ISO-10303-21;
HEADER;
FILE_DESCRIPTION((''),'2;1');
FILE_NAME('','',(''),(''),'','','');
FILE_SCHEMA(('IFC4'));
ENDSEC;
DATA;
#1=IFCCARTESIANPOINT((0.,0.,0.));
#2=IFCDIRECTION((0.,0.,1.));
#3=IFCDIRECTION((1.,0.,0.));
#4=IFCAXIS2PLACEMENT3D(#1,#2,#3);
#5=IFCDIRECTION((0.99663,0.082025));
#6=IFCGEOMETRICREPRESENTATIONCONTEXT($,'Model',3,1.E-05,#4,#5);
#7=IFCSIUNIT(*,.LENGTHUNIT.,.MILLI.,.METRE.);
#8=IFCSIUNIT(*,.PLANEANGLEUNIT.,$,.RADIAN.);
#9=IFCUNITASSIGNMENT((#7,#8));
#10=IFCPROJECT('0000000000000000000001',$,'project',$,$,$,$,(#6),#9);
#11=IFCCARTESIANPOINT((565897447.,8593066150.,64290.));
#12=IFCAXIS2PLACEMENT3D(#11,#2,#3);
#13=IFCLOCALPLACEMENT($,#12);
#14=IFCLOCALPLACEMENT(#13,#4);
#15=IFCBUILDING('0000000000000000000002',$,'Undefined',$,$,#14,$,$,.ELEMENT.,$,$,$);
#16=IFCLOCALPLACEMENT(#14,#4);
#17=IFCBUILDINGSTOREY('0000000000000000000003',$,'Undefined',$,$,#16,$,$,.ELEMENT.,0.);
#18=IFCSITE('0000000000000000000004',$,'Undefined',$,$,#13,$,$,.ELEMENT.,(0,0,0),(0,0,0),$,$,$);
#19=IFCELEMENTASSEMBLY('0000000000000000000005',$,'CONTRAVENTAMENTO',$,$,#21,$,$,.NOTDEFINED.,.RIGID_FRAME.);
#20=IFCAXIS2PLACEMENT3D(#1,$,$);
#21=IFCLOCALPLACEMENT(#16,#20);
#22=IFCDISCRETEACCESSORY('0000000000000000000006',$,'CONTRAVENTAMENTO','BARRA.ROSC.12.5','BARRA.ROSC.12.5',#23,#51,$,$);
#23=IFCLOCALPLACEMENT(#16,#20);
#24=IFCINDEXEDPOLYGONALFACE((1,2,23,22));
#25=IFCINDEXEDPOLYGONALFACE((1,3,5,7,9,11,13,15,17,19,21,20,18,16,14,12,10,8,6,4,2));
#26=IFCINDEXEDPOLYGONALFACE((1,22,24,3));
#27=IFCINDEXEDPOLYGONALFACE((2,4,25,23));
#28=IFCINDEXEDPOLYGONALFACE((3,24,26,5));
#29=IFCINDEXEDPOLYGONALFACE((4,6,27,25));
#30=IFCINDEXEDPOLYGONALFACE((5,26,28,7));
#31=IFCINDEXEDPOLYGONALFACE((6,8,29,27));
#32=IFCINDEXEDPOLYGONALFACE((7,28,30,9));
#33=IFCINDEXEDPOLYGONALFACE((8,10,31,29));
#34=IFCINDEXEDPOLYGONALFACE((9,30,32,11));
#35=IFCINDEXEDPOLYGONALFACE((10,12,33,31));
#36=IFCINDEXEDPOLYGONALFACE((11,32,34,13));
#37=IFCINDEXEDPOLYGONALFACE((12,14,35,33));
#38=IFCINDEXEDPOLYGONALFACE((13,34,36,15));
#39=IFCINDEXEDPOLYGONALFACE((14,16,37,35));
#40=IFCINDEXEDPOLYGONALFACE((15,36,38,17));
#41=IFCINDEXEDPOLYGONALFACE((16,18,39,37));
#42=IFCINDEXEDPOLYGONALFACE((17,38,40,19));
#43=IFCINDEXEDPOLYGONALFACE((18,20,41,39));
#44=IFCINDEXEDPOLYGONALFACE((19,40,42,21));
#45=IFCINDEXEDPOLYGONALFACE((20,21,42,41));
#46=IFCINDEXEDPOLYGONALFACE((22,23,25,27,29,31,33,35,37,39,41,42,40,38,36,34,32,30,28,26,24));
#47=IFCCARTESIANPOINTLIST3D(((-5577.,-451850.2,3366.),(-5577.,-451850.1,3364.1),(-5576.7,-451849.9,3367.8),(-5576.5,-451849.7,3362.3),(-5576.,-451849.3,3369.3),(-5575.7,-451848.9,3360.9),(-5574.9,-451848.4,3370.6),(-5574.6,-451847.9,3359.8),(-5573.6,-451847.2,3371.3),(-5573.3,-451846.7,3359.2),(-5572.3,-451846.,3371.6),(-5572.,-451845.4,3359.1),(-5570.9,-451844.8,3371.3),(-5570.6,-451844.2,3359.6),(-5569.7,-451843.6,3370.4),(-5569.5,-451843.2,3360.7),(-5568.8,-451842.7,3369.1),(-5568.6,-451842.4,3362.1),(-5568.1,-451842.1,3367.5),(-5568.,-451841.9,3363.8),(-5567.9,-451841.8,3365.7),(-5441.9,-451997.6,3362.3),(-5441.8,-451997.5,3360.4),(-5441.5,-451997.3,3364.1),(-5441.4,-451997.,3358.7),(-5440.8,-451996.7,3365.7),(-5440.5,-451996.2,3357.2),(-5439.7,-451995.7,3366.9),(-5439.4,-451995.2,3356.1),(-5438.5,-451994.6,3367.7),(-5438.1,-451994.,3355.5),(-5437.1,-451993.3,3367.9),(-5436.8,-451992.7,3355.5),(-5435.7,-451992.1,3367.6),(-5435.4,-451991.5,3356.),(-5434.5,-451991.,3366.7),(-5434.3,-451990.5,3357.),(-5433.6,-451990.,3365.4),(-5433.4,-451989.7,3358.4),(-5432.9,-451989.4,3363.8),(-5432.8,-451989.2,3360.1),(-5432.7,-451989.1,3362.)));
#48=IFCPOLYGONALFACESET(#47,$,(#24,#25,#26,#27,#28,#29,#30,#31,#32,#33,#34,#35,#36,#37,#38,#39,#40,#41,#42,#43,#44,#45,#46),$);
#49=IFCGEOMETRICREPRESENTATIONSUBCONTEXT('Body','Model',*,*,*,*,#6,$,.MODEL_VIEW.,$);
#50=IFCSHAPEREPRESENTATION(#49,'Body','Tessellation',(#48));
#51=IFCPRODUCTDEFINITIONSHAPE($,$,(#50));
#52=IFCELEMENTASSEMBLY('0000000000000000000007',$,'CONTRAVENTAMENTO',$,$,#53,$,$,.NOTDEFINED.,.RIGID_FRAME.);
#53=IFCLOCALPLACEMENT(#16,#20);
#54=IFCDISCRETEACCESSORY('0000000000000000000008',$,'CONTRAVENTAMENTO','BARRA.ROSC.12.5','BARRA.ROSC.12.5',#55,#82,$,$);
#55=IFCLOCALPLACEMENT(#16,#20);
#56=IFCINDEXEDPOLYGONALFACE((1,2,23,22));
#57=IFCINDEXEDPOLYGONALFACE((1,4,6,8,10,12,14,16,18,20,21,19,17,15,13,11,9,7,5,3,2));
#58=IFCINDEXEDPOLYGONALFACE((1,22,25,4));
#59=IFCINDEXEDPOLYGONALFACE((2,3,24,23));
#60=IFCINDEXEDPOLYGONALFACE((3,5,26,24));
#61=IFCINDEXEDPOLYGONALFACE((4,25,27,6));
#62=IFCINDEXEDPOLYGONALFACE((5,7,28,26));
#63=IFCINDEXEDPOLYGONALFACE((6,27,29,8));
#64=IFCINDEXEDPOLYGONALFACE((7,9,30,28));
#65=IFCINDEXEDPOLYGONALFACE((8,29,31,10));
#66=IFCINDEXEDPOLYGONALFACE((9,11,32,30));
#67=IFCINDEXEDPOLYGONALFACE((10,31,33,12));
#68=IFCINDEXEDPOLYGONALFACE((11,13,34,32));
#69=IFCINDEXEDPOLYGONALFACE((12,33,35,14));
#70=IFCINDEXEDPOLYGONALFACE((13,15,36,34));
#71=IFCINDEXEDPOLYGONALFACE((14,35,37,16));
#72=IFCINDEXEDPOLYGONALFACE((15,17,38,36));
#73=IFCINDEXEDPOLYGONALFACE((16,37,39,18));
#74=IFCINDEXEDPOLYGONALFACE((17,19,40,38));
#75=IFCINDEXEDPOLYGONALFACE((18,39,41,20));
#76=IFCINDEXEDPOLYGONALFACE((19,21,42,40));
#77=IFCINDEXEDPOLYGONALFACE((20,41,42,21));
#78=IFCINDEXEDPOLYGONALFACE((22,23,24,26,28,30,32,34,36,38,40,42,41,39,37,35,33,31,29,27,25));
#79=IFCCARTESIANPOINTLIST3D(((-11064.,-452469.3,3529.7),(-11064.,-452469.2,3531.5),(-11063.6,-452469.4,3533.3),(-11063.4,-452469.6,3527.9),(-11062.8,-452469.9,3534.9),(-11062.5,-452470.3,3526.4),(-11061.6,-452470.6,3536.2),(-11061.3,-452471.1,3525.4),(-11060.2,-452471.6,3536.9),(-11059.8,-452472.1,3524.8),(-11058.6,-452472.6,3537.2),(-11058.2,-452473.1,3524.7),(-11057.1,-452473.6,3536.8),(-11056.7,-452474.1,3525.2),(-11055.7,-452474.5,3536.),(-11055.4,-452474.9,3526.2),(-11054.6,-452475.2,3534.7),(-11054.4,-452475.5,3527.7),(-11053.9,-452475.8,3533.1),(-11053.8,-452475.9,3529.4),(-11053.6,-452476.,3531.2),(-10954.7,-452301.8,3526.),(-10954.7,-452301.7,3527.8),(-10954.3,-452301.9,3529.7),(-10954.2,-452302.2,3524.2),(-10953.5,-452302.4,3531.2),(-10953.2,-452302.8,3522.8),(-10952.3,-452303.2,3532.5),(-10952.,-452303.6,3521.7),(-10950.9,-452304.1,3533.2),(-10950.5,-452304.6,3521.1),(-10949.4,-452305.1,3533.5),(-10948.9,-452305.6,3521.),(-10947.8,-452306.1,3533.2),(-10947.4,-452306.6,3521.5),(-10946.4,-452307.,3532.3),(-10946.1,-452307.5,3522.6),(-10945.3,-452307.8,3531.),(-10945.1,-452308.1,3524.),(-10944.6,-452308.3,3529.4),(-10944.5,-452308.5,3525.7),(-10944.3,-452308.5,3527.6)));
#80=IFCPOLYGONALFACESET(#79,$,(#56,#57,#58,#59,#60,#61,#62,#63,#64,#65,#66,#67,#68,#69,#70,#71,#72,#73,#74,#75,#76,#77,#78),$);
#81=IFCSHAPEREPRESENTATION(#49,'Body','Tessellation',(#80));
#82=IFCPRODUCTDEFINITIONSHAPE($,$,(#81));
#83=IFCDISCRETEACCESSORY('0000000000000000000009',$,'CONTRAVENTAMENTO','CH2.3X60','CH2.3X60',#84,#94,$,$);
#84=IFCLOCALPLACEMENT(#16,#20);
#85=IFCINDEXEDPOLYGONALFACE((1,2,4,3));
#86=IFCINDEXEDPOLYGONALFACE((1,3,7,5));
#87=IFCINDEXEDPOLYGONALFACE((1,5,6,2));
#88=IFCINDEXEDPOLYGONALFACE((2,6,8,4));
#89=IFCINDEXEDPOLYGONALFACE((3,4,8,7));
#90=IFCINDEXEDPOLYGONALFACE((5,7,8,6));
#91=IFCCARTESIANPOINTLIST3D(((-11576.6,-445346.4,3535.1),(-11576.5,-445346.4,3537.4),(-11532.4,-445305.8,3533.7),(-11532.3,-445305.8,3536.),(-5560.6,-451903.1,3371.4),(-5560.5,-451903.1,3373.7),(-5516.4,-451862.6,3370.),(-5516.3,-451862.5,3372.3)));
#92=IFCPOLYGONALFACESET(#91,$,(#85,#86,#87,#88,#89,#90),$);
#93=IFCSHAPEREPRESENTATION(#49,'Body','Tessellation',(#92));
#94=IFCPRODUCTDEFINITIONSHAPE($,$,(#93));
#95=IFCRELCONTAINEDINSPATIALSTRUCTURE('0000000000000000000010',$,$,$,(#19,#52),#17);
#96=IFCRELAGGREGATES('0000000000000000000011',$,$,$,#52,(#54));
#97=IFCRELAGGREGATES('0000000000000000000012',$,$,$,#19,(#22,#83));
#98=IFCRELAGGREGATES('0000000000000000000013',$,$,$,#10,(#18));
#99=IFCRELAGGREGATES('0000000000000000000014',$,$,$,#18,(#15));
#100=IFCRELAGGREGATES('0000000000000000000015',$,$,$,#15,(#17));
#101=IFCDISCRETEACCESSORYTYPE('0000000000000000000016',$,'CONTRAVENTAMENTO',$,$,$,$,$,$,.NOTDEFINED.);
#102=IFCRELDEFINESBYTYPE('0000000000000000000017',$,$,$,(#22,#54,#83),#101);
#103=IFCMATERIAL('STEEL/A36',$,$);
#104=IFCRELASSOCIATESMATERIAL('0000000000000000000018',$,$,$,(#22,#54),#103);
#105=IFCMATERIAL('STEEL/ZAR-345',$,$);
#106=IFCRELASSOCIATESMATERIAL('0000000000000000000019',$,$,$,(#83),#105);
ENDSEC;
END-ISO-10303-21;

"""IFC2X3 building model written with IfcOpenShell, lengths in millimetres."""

from ifc_helpers import new_model, si_unit, direction, frame, origin_with_axes, origin_2d_with_axis, place, context, subcontext, project, spatial, polyline, circle, outline, extrude, material, type_object, element, aggregate, save


model = new_model("IFC2X3")

# Units and contexts
model_context = context("Model", 3, precision=1e-05, world=origin_with_axes(), true_north=direction((0.99663, 0.082025)))
body_context = subcontext(model_context, "Body", "Model", "MODEL_VIEW")
ifc_project = project(units=[si_unit("LENGTHUNIT", "METRE", prefix="MILLI"), si_unit("PLANEANGLEUNIT", "RADIAN")], contexts=[model_context])

# Site, building, storey
site_placement = place(None, frame((565897447.0, 8593066150.0, 64290.0), z_axis=(0.0, 0.0, 1.0), x_axis=(1.0, 0.0, 0.0)))
site = spatial("IfcSite", under=ifc_project, at=site_placement, Name="Undefined", CompositionType="ELEMENT", RefLatitude=(0, 0, 0), RefLongitude=(0, 0, 0))
building_placement = place(site_placement, origin_with_axes())
building = spatial("IfcBuilding", under=site, at=building_placement, Name="Undefined", CompositionType="ELEMENT")
storey_placement = place(building_placement, origin_with_axes())
storey = spatial("IfcBuildingStorey", under=building, at=storey_placement, Name="Undefined", CompositionType="ELEMENT", Elevation=0.0)

# Shared definitions
ifc_material_1 = material(Name="STEEL/A36")

# Element assemblies, discrete accessories
assembly_1_placement = place(storey_placement, origin_with_axes())
assembly_1 = element("IfcElementAssembly", 1, at=assembly_1_placement, inside=storey, Name="CONTRAVENTAMENTO", AssemblyPlace="NOTDEFINED", PredefinedType="RIGID_FRAME")
discrete_accessory_type_1 = type_object("IfcDiscreteAccessoryType", Name="CONTRAVENTAMENTO")
discrete_accessory_1_placement = place(assembly_1_placement, frame((-5437.3, -451993.4, 3361.7), z_axis=(-0.736334, -0.676203, 0.02368), x_axis=(-0.675958, 0.736711, 0.018398)))
discrete_accessory_1 = element("IfcDiscreteAccessory", 2, at=discrete_accessory_1_placement, type_object=discrete_accessory_type_1, material=ifc_material_1, Name="CONTRAVENTAMENTO", Description="BARRA.ROSC.12.5", ObjectType="BARRA.ROSC.12.5", context=body_context, shape_type="SweptSolid", body=[
    extrude(circle(Radius=6.2, at=origin_2d_with_axis()), frame((200.0, 0.0, 0.0), z_axis=(-1.0, 0.0, 0.0), x_axis=(0.0, -1.0, 0.0)), (0.0, 0.0, 1.0), 200.0),
])
assembly_2_placement = place(storey_placement, origin_with_axes())
assembly_2 = element("IfcElementAssembly", 3, at=assembly_2_placement, inside=storey, Name="CONTRAVENTAMENTO", AssemblyPlace="NOTDEFINED", PredefinedType="RIGID_FRAME")
discrete_accessory_2_placement = place(assembly_2_placement, frame((-11058.8, -452472.6, 3530.9), z_axis=(-0.836984, 0.546715, 0.02368), x_axis=(0.546411, 0.837315, -0.018398)))
discrete_accessory_2 = element("IfcDiscreteAccessory", 4, at=discrete_accessory_2_placement, type_object=discrete_accessory_type_1, material=ifc_material_1, Name="CONTRAVENTAMENTO", Description="BARRA.ROSC.12.5", ObjectType="BARRA.ROSC.12.5", context=body_context, shape_type="SweptSolid", body=[
    extrude(circle(Radius=6.2, at=origin_2d_with_axis()), frame((200.0, 0.0, 0.0), z_axis=(-1.0, 0.0, 0.0), x_axis=(0.0, -1.0, 0.0)), (0.0, 0.0, 1.0), 200.0),
])
aggregate(assembly_2, [discrete_accessory_2])

# Discrete accessory
ifc_material_2 = material(Name="STEEL/ZAR-345")
discrete_accessory_3_placement = place(assembly_1_placement, frame((-5538.5, -451882.8, 3371.8), z_axis=(0.029885, 0.00246, 0.99955), x_axis=(-0.675958, 0.736711, 0.018398)))
discrete_accessory_3 = element("IfcDiscreteAccessory", 5, at=discrete_accessory_3_placement, type_object=discrete_accessory_type_1, material=ifc_material_2, Name="CONTRAVENTAMENTO", Description="CH2.3X60", ObjectType="CH2.3X60", context=body_context, shape_type="SweptSolid", body=[
    extrude(outline(polyline([(8900.0, -30.0), (0.0, -30.0), (0.0, 30.0), (8900.0, 30.0), (8900.0, -30.0)])), frame((0.0, 0.0, -1.1), z_axis=(0.0, 0.0, 1.0), x_axis=(1.0, 0.0, 0.0)), (0.0, 0.0, 1.0), 2.3),
])
aggregate(assembly_1, [discrete_accessory_1, discrete_accessory_3])

save(model, "model.ifc")
